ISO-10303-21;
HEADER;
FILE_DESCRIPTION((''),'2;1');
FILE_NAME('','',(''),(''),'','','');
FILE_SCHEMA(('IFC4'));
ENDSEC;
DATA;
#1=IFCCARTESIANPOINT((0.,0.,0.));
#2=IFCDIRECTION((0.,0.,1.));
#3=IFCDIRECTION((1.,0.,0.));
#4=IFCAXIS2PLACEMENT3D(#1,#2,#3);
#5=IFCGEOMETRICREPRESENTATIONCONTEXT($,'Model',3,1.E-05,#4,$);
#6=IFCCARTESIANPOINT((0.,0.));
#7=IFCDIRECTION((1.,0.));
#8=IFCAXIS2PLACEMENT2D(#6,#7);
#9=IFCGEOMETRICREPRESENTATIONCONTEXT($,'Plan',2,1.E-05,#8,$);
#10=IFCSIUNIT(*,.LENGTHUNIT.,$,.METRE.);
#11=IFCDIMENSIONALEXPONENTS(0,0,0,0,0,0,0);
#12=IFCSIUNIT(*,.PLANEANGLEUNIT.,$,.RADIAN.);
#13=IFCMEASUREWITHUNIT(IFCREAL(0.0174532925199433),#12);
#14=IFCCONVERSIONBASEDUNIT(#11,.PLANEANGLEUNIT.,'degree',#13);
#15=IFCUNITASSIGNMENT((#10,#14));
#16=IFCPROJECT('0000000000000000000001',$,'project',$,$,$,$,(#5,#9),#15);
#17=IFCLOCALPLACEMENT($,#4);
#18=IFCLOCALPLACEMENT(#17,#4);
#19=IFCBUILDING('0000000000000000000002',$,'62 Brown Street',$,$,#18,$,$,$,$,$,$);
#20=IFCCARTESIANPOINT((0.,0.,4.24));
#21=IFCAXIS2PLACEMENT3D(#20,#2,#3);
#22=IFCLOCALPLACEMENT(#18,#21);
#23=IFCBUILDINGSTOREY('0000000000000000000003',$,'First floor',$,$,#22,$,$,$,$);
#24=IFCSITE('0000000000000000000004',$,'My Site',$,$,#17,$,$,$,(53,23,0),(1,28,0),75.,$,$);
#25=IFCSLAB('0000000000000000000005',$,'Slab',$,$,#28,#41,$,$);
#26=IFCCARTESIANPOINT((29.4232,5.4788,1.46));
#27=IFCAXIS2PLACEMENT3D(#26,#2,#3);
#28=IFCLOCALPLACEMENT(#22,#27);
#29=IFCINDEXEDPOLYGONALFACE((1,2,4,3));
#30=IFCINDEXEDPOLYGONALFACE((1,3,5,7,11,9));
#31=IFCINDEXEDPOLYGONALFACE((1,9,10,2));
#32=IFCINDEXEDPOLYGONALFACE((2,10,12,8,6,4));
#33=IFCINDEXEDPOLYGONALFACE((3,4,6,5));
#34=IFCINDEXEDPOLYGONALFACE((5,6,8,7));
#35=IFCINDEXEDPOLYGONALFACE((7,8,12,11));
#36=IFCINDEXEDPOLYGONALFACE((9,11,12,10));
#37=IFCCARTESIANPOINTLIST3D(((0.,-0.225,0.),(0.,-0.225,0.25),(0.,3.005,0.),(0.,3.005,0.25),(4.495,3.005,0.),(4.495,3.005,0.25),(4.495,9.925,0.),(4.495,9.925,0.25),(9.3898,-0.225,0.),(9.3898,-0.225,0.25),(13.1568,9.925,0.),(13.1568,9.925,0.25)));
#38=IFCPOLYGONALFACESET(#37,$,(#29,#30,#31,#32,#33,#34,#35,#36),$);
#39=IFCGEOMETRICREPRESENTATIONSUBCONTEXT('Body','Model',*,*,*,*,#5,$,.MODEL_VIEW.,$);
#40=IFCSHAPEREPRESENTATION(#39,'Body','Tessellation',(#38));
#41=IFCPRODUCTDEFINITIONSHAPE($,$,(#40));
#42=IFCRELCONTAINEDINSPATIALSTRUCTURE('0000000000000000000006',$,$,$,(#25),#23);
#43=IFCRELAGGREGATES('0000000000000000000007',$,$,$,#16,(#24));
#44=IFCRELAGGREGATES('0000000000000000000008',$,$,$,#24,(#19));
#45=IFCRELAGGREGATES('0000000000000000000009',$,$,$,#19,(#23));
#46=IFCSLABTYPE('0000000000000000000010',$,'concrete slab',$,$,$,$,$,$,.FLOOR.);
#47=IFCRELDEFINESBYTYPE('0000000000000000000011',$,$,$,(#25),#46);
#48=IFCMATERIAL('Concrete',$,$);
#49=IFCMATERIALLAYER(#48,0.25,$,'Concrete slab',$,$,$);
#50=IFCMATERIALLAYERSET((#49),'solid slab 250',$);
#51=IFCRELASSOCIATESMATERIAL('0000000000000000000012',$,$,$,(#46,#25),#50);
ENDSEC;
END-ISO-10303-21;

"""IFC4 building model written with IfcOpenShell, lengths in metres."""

from ifc_helpers import new_model, entity, si_unit, converted_unit, frame, origin_with_axes, origin_2d_with_axis, place, context, subcontext, project, spatial, line, indexed_curve, outline, extrude, material, layer, layer_set, layer_usage, type_object, element, save


model = new_model("IFC4")

# Units and contexts
model_context = context("Model", 3, precision=1e-05, world=origin_with_axes())
plan_context = context("Plan", 2, precision=1e-05, world=origin_2d_with_axis())
body_context_1 = subcontext(model_context, "Body", "Model", "MODEL_VIEW")
ifc_project = project(units=[si_unit("LENGTHUNIT", "METRE"), converted_unit("PLANEANGLEUNIT", "degree", entity("IfcReal", 0.0174532925199433), si_unit("PLANEANGLEUNIT", "RADIAN"), dimensions=[0, 0, 0, 0, 0, 0, 0])], contexts=[model_context, plan_context])

# Site, building, storey
site_placement = place(None, origin_with_axes())
site = spatial("IfcSite", under=ifc_project, at=site_placement, Name="My Site", RefLatitude=(53, 23, 0), RefLongitude=(1, 28, 0), RefElevation=75.0)
building_placement = place(site_placement, origin_with_axes())
building = spatial("IfcBuilding", under=site, at=building_placement, Name="62 Brown Street")
storey_placement = place(building_placement, frame((0.0, 0.0, 4.24), z_axis=(0.0, 0.0, 1.0), x_axis=(1.0, 0.0, 0.0)))
storey = spatial("IfcBuildingStorey", under=building, at=storey_placement, Name="First floor")

# Slab
ifc_material_1 = material(Name="Concrete")
ifc_layer_1 = layer(ifc_material_1, 0.25, Name="Concrete slab")
ifc_layer_set_1 = layer_set([ifc_layer_1], Name="solid slab 250")
slab_type = type_object("IfcSlabType", Name="concrete slab", PredefinedType="FLOOR", material=ifc_layer_set_1)
ifc_layer_usage_1 = layer_usage(ifc_layer_set_1, "AXIS3", "POSITIVE", 0.0)
slab_1_placement = place(storey_placement, frame((29.4232, 5.4788, 1.46), z_axis=(0.0, 0.0, 1.0), x_axis=(1.0, 0.0, 0.0)))
element("IfcSlab", 1, at=slab_1_placement, inside=storey, type_object=slab_type, material=ifc_layer_usage_1, Name="Slab", context=body_context_1, shape_type="SweptSolid", body=[
    extrude(outline(indexed_curve([(0.0, 3.005), (0.0, -0.225), (9.3898, -0.225), (13.1568, 9.925), (4.495, 9.925), (4.495, 3.005)], segments=[line(4, 3), line(3, 2), line(2, 1), line(1, 6), line(6, 5), line(5, 4)], self_intersect=False)), None, (0.0, 0.0, 1.0), 0.25),
])

save(model, "model.ifc")
